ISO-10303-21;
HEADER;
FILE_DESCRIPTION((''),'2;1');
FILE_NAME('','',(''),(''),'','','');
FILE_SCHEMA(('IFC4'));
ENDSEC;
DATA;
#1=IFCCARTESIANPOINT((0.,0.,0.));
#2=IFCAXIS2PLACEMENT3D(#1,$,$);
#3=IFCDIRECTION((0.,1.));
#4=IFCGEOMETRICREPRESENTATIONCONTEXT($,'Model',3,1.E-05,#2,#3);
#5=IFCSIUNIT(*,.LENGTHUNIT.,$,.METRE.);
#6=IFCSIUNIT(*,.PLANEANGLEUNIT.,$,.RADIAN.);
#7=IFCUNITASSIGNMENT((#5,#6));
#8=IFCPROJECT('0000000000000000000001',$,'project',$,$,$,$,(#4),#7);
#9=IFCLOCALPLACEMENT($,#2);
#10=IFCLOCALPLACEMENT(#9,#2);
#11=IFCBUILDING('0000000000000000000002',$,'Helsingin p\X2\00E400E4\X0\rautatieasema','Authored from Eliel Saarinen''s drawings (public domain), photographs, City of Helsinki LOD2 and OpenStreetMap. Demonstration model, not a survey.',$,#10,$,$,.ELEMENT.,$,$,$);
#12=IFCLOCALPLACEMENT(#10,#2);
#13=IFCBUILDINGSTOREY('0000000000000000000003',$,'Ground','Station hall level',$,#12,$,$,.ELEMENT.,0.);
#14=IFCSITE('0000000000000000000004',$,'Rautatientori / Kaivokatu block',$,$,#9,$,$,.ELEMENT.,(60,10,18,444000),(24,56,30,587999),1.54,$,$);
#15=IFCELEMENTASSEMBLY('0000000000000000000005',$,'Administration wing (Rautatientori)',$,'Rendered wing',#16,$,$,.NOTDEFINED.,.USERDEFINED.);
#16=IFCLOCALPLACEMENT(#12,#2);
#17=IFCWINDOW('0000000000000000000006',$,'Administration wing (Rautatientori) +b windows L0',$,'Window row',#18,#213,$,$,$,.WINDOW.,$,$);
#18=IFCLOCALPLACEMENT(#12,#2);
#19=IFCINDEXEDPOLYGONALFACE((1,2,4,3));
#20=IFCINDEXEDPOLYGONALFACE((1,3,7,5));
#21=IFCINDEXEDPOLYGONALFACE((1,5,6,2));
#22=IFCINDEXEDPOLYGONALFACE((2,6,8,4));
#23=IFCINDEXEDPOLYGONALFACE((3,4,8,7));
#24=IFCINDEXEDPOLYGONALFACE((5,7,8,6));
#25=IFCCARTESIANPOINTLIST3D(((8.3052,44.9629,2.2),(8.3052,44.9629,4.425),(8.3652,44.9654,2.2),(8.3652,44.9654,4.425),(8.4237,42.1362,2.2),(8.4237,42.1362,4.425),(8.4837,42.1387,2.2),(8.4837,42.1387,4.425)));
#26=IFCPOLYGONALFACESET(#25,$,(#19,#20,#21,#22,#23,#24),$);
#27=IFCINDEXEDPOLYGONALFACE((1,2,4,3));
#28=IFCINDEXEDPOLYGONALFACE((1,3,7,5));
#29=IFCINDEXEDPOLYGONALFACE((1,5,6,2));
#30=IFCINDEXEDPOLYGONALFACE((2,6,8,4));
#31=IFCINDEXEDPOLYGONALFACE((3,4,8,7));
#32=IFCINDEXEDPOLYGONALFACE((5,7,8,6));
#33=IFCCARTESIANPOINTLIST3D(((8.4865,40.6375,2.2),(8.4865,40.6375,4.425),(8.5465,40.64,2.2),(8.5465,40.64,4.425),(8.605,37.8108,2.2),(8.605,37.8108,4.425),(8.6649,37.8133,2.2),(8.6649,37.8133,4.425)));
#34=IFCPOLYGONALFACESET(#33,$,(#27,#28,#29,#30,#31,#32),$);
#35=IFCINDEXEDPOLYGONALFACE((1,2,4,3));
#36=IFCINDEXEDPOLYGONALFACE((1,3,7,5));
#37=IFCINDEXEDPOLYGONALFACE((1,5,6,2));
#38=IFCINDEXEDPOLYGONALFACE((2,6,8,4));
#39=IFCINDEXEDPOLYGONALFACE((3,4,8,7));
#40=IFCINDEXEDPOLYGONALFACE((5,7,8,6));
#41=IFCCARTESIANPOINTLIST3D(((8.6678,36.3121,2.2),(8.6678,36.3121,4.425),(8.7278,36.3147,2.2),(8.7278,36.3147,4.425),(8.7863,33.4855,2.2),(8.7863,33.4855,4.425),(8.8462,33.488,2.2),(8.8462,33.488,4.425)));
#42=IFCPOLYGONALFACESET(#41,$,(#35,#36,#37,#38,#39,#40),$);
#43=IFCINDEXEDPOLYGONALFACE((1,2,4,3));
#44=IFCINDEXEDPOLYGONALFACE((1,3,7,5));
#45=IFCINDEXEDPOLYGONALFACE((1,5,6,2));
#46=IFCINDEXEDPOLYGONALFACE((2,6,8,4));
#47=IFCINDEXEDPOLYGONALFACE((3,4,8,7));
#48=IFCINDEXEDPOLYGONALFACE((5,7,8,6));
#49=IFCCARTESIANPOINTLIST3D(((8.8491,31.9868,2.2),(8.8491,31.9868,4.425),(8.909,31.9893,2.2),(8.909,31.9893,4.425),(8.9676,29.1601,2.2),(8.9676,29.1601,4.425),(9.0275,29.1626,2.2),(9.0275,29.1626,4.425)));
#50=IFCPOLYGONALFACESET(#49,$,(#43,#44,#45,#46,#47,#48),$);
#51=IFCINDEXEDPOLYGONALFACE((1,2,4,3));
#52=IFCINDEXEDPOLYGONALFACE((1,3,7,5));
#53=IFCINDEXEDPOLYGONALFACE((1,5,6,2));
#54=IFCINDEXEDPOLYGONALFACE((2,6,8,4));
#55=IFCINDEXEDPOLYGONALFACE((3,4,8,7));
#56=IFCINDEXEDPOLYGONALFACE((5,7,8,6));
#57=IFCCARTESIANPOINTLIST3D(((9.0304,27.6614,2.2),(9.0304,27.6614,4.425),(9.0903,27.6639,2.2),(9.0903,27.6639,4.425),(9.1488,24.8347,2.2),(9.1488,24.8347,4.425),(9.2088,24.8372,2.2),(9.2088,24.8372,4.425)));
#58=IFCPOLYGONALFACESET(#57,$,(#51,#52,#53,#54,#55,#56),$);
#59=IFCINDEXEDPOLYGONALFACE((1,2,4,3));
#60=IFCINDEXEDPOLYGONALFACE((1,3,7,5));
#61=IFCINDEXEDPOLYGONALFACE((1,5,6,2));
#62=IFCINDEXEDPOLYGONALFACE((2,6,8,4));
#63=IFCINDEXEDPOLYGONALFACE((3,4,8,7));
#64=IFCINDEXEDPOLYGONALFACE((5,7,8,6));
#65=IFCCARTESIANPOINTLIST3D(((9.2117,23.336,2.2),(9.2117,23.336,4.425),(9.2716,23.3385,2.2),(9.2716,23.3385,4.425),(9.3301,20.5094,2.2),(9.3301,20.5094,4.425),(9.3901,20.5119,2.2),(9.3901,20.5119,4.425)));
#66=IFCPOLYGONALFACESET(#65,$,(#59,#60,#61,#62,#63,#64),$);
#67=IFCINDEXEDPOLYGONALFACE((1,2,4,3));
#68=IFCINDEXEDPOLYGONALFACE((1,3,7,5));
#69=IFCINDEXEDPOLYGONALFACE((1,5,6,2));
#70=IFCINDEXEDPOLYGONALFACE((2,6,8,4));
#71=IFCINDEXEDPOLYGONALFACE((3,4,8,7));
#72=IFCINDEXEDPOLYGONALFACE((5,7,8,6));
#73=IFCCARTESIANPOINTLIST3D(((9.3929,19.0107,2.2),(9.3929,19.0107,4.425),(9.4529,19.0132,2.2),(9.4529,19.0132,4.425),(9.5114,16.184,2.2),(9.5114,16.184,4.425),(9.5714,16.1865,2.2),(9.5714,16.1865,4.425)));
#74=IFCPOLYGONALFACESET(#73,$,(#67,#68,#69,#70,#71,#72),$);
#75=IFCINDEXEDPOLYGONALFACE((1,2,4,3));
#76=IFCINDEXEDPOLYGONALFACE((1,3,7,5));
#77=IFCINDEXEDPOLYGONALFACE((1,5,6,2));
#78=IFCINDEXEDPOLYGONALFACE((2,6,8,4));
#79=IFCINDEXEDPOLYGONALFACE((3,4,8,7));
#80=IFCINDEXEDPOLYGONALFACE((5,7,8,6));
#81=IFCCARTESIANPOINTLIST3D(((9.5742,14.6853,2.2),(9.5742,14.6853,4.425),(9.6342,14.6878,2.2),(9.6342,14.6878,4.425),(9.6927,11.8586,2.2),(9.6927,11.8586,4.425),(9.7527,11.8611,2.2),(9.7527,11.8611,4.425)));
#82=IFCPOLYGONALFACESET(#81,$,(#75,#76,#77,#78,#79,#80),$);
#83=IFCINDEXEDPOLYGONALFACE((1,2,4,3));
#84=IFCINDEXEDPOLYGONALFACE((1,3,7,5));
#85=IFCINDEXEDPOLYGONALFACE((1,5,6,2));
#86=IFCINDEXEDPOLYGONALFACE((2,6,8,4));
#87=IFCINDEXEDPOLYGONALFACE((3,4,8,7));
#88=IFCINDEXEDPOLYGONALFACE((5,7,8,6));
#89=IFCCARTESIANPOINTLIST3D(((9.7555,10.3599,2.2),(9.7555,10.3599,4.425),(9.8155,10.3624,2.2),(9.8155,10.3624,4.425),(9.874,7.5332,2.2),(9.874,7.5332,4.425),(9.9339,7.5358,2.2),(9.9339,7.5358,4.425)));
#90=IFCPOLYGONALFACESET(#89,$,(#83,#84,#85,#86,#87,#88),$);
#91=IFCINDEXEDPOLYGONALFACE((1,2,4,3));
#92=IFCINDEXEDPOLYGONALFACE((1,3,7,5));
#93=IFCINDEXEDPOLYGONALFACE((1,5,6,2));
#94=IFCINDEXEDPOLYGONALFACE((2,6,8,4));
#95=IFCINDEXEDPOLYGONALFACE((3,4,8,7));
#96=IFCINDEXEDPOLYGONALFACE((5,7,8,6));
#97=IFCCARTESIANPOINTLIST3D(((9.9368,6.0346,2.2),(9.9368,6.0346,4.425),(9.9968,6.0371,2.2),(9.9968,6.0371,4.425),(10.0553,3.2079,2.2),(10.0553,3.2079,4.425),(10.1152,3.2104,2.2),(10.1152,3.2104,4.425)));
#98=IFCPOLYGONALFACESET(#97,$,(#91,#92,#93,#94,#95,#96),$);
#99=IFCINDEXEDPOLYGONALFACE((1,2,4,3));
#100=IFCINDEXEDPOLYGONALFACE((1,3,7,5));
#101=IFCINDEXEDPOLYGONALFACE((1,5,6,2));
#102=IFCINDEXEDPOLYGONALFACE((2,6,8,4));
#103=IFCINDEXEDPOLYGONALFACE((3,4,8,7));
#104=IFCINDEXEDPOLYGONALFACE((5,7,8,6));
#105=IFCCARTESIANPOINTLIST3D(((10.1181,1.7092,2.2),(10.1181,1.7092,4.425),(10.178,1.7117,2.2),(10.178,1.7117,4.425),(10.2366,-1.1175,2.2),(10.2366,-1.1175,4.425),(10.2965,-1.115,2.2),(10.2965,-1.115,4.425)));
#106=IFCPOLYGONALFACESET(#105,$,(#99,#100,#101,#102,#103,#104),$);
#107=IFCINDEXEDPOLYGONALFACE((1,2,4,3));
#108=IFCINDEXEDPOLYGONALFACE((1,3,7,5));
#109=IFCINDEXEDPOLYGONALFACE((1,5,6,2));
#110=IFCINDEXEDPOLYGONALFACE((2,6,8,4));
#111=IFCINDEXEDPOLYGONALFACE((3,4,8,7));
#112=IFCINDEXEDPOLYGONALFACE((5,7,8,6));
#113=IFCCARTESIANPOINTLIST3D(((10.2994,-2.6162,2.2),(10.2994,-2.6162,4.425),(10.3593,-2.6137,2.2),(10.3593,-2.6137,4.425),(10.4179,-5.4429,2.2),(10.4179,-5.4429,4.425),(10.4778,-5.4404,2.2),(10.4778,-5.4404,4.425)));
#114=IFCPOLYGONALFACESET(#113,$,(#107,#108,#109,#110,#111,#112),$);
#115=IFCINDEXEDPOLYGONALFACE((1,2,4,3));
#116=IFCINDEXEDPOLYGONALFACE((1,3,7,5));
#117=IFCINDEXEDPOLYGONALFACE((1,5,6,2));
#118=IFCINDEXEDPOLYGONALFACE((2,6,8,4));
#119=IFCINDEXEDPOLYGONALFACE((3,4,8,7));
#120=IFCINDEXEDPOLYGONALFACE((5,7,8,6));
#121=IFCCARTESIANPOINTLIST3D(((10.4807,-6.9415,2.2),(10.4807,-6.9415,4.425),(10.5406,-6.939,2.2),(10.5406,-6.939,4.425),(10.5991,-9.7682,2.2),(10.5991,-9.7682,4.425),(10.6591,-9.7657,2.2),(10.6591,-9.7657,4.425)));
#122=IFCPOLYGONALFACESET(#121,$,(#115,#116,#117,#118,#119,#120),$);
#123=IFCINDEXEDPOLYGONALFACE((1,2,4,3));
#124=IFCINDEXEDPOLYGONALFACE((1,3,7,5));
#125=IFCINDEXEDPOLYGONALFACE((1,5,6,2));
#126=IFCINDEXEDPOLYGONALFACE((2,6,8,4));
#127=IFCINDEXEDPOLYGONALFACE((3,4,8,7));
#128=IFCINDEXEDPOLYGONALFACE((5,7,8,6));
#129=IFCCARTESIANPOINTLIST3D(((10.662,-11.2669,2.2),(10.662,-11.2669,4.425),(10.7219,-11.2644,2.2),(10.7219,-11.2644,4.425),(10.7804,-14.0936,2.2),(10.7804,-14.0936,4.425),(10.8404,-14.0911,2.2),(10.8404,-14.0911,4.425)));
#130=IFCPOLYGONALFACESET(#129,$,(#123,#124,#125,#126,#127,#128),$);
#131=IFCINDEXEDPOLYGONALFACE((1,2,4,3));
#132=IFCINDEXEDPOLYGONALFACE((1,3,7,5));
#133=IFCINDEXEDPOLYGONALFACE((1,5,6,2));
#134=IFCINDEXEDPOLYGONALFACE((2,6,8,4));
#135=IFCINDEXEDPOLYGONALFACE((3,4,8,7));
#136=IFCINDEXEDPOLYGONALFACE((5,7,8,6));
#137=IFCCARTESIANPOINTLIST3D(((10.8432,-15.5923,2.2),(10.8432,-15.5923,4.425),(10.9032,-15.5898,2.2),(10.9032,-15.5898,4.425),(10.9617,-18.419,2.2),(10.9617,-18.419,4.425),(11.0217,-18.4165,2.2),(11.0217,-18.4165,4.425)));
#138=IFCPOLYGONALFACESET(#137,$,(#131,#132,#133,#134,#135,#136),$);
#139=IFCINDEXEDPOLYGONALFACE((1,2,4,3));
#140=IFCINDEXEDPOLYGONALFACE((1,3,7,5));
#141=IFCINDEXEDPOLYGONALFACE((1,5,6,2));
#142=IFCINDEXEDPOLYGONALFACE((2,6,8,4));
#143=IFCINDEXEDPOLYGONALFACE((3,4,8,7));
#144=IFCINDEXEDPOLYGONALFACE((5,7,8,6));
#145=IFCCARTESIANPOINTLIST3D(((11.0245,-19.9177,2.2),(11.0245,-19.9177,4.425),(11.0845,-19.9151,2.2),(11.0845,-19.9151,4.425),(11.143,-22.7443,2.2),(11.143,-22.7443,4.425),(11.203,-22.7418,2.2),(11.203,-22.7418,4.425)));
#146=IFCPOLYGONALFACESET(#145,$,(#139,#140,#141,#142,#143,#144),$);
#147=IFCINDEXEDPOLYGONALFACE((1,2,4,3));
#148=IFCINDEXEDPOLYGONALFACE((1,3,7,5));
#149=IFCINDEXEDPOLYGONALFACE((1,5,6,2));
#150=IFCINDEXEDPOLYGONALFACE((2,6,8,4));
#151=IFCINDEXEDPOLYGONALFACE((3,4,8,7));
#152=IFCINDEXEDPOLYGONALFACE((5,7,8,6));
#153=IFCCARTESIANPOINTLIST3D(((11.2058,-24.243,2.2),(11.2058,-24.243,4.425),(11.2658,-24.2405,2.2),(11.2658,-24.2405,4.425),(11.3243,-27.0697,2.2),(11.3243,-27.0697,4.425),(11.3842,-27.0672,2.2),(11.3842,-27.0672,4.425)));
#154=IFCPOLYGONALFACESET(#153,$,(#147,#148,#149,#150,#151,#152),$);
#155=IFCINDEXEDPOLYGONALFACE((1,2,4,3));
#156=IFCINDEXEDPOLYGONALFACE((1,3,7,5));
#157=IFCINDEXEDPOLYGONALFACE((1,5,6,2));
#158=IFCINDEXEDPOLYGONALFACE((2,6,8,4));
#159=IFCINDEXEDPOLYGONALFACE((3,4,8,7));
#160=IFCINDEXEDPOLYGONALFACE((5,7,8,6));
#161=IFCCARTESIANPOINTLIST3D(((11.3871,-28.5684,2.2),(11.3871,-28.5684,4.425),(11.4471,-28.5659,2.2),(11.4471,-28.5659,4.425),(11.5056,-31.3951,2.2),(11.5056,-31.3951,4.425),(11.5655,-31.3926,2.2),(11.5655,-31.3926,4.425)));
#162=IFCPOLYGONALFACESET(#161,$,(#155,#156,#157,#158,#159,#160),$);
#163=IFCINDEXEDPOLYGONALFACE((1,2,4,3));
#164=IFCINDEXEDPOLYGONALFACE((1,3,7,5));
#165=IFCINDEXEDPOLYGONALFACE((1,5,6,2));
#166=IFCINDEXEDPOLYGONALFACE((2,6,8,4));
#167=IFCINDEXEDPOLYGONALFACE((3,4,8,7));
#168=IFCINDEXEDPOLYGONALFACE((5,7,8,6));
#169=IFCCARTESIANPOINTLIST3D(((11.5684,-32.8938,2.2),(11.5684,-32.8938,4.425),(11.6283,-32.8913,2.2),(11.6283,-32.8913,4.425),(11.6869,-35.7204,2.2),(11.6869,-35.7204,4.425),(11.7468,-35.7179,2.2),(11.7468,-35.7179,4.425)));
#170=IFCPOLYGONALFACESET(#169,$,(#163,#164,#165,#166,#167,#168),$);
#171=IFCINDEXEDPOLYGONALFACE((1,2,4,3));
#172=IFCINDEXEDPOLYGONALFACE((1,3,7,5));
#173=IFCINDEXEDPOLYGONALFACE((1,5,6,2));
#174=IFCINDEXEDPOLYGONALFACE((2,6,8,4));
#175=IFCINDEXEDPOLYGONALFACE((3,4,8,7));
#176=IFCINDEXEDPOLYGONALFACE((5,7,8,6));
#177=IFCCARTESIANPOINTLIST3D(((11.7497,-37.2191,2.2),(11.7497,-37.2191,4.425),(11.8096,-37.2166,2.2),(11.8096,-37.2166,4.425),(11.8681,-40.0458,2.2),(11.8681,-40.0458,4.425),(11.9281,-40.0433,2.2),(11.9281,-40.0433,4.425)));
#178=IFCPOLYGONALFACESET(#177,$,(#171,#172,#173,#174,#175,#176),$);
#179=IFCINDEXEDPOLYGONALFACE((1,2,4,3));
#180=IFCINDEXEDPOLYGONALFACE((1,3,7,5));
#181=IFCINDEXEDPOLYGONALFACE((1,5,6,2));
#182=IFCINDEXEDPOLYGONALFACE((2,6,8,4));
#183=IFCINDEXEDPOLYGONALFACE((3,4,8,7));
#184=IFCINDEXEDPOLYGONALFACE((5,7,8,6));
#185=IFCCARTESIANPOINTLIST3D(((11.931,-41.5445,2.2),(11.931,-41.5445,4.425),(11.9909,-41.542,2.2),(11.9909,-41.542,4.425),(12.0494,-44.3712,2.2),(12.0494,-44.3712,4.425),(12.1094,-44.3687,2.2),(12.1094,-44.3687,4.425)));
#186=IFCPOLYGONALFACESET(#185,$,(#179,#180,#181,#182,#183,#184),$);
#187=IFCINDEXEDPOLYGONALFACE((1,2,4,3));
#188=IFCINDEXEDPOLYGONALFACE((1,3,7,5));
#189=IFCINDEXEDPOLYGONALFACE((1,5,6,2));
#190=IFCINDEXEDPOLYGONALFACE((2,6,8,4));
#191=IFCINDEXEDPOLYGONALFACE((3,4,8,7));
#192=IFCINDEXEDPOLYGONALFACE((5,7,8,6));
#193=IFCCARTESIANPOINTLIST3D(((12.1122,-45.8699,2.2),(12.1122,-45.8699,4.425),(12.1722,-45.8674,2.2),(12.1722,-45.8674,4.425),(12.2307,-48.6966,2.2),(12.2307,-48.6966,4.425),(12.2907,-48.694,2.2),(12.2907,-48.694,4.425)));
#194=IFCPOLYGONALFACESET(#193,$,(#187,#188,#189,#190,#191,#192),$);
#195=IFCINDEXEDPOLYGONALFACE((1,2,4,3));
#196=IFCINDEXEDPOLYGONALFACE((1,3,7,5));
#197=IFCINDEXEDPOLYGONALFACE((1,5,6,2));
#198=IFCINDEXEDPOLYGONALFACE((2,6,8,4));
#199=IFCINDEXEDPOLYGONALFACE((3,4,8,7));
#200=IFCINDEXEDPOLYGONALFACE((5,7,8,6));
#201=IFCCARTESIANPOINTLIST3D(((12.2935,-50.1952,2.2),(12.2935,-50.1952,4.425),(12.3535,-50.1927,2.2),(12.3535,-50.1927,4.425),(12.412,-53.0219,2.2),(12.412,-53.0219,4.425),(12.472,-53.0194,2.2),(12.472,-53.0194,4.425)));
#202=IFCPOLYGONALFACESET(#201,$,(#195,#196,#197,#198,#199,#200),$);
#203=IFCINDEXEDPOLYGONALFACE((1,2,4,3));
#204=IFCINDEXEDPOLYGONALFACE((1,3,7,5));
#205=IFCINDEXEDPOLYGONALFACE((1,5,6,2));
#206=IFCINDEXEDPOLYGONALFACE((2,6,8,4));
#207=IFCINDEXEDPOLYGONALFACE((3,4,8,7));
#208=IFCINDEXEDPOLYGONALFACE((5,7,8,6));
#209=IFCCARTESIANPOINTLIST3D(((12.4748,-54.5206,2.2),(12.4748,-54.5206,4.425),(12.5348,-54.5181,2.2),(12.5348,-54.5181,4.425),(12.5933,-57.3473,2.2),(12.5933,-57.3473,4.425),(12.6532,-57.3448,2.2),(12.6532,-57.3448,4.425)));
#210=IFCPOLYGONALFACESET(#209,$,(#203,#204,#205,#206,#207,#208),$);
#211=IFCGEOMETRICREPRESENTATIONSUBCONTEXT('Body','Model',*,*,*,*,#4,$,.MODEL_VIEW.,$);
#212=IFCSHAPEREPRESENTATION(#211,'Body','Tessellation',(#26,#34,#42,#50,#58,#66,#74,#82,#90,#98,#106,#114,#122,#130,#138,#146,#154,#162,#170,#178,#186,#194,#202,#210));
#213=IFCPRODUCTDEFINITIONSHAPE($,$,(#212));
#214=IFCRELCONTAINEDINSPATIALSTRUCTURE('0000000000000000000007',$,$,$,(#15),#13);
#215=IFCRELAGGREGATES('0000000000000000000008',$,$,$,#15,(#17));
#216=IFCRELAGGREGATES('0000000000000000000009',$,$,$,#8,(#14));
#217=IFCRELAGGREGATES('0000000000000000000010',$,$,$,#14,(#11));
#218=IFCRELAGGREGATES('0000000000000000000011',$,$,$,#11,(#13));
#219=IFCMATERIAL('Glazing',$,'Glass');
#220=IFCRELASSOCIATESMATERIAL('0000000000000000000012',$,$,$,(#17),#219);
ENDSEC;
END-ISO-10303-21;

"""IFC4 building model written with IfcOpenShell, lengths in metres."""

from ifc_helpers import new_model, si_unit, direction, frame, frame_2d, origin, place, context, subcontext, project, spatial, rectangle, extrude, material, element, aggregate, save


model = new_model("IFC4")

# Units and contexts
model_context = context("Model", 3, precision=1e-05, world=origin(), true_north=direction((0.0, 1.0)))
body_context = subcontext(model_context, "Body", "Model", "MODEL_VIEW")
ifc_project = project(units=[si_unit("LENGTHUNIT", "METRE"), si_unit("PLANEANGLEUNIT", "RADIAN")], contexts=[model_context])

# Site, building, storey
site_placement = place(None, origin())
site = spatial("IfcSite", under=ifc_project, at=site_placement, Name="Rautatientori / Kaivokatu block", CompositionType="ELEMENT", RefLatitude=(60, 10, 18, 444000), RefLongitude=(24, 56, 30, 587999), RefElevation=1.54)
building_placement = place(site_placement, origin())
building = spatial("IfcBuilding", under=site, at=building_placement, Name="Helsingin päärautatieasema", Description="Authored from Eliel Saarinen's drawings (public domain), photographs, City of Helsinki LOD2 and OpenStreetMap. Demonstration model, not a survey.", CompositionType="ELEMENT")
storey_placement = place(building_placement, origin())
storey = spatial("IfcBuildingStorey", under=building, at=storey_placement, Name="Ground", Description="Station hall level", CompositionType="ELEMENT", Elevation=0.0)

# Element assembly, window
assembly_placement = place(building_placement, origin())
assembly = element("IfcElementAssembly", 1, at=assembly_placement, inside=storey, Name="Administration wing (Rautatientori)", ObjectType="Rendered wing", AssemblyPlace="NOTDEFINED", PredefinedType="USERDEFINED")
ifc_material_1 = material(Name="Glazing", Category="Glass")
window_1_placement = place(building_placement, origin())
window_1 = element("IfcWindow", 2, at=window_1_placement, material=ifc_material_1, Name="Administration wing (Rautatientori) +b windows L0", ObjectType="Window row", PredefinedType="WINDOW", context=body_context, shape_type="SweptSolid", body=[
    extrude(rectangle(XDim=2.8292, YDim=0.06, at=frame_2d((0.0, 0.0), x_axis=(0.041876, -0.999123))), frame((8.3944, 43.5508, 2.2)), (0.0, 0.0, 1.0), 2.225),
    extrude(rectangle(XDim=2.8292, YDim=0.06, at=frame_2d((0.0, 0.0), x_axis=(0.041876, -0.999123))), frame((8.5757, 39.2254, 2.2)), (0.0, 0.0, 1.0), 2.225),
    extrude(rectangle(XDim=2.8292, YDim=0.06, at=frame_2d((0.0, 0.0), x_axis=(0.041876, -0.999123))), frame((8.757, 34.9001, 2.2)), (0.0, 0.0, 1.0), 2.225),
    extrude(rectangle(XDim=2.8292, YDim=0.06, at=frame_2d((0.0, 0.0), x_axis=(0.041876, -0.999123))), frame((8.9383, 30.5747, 2.2)), (0.0, 0.0, 1.0), 2.225),
    extrude(rectangle(XDim=2.8292, YDim=0.06, at=frame_2d((0.0, 0.0), x_axis=(0.041876, -0.999123))), frame((9.1196, 26.2493, 2.2)), (0.0, 0.0, 1.0), 2.225),
    extrude(rectangle(XDim=2.8292, YDim=0.06, at=frame_2d((0.0, 0.0), x_axis=(0.041876, -0.999123))), frame((9.3009, 21.9239, 2.2)), (0.0, 0.0, 1.0), 2.225),
    extrude(rectangle(XDim=2.8292, YDim=0.06, at=frame_2d((0.0, 0.0), x_axis=(0.041876, -0.999123))), frame((9.4822, 17.5986, 2.2)), (0.0, 0.0, 1.0), 2.225),
    extrude(rectangle(XDim=2.8292, YDim=0.06, at=frame_2d((0.0, 0.0), x_axis=(0.041876, -0.999123))), frame((9.6634, 13.2732, 2.2)), (0.0, 0.0, 1.0), 2.225),
    extrude(rectangle(XDim=2.8292, YDim=0.06, at=frame_2d((0.0, 0.0), x_axis=(0.041876, -0.999123))), frame((9.8447, 8.9478, 2.2)), (0.0, 0.0, 1.0), 2.225),
    extrude(rectangle(XDim=2.8292, YDim=0.06, at=frame_2d((0.0, 0.0), x_axis=(0.041876, -0.999123))), frame((10.026, 4.6225, 2.2)), (0.0, 0.0, 1.0), 2.225),
    extrude(rectangle(XDim=2.8292, YDim=0.06, at=frame_2d((0.0, 0.0), x_axis=(0.041876, -0.999123))), frame((10.2073, 0.2971, 2.2)), (0.0, 0.0, 1.0), 2.225),
    extrude(rectangle(XDim=2.8292, YDim=0.06, at=frame_2d((0.0, 0.0), x_axis=(0.041876, -0.999123))), frame((10.3886, -4.0283, 2.2)), (0.0, 0.0, 1.0), 2.225),
    extrude(rectangle(XDim=2.8292, YDim=0.06, at=frame_2d((0.0, 0.0), x_axis=(0.041876, -0.999123))), frame((10.5699, -8.3536, 2.2)), (0.0, 0.0, 1.0), 2.225),
    extrude(rectangle(XDim=2.8292, YDim=0.06, at=frame_2d((0.0, 0.0), x_axis=(0.041876, -0.999123))), frame((10.7512, -12.679, 2.2)), (0.0, 0.0, 1.0), 2.225),
    extrude(rectangle(XDim=2.8292, YDim=0.06, at=frame_2d((0.0, 0.0), x_axis=(0.041876, -0.999123))), frame((10.9325, -17.0044, 2.2)), (0.0, 0.0, 1.0), 2.225),
    extrude(rectangle(XDim=2.8292, YDim=0.06, at=frame_2d((0.0, 0.0), x_axis=(0.041876, -0.999123))), frame((11.1137, -21.3297, 2.2)), (0.0, 0.0, 1.0), 2.225),
    extrude(rectangle(XDim=2.8292, YDim=0.06, at=frame_2d((0.0, 0.0), x_axis=(0.041876, -0.999123))), frame((11.295, -25.6551, 2.2)), (0.0, 0.0, 1.0), 2.225),
    extrude(rectangle(XDim=2.8292, YDim=0.06, at=frame_2d((0.0, 0.0), x_axis=(0.041876, -0.999123))), frame((11.4763, -29.9805, 2.2)), (0.0, 0.0, 1.0), 2.225),
    extrude(rectangle(XDim=2.8292, YDim=0.06, at=frame_2d((0.0, 0.0), x_axis=(0.041876, -0.999123))), frame((11.6576, -34.3059, 2.2)), (0.0, 0.0, 1.0), 2.225),
    extrude(rectangle(XDim=2.8292, YDim=0.06, at=frame_2d((0.0, 0.0), x_axis=(0.041876, -0.999123))), frame((11.8389, -38.6312, 2.2)), (0.0, 0.0, 1.0), 2.225),
    extrude(rectangle(XDim=2.8292, YDim=0.06, at=frame_2d((0.0, 0.0), x_axis=(0.041876, -0.999123))), frame((12.0202, -42.9566, 2.2)), (0.0, 0.0, 1.0), 2.225),
    extrude(rectangle(XDim=2.8292, YDim=0.06, at=frame_2d((0.0, 0.0), x_axis=(0.041876, -0.999123))), frame((12.2015, -47.282, 2.2)), (0.0, 0.0, 1.0), 2.225),
    extrude(rectangle(XDim=2.8292, YDim=0.06, at=frame_2d((0.0, 0.0), x_axis=(0.041876, -0.999123))), frame((12.3827, -51.6073, 2.2)), (0.0, 0.0, 1.0), 2.225),
    extrude(rectangle(XDim=2.8292, YDim=0.06, at=frame_2d((0.0, 0.0), x_axis=(0.041876, -0.999123))), frame((12.564, -55.9327, 2.2)), (0.0, 0.0, 1.0), 2.225),
])
aggregate(assembly, [window_1])

save(model, "model.ifc")
